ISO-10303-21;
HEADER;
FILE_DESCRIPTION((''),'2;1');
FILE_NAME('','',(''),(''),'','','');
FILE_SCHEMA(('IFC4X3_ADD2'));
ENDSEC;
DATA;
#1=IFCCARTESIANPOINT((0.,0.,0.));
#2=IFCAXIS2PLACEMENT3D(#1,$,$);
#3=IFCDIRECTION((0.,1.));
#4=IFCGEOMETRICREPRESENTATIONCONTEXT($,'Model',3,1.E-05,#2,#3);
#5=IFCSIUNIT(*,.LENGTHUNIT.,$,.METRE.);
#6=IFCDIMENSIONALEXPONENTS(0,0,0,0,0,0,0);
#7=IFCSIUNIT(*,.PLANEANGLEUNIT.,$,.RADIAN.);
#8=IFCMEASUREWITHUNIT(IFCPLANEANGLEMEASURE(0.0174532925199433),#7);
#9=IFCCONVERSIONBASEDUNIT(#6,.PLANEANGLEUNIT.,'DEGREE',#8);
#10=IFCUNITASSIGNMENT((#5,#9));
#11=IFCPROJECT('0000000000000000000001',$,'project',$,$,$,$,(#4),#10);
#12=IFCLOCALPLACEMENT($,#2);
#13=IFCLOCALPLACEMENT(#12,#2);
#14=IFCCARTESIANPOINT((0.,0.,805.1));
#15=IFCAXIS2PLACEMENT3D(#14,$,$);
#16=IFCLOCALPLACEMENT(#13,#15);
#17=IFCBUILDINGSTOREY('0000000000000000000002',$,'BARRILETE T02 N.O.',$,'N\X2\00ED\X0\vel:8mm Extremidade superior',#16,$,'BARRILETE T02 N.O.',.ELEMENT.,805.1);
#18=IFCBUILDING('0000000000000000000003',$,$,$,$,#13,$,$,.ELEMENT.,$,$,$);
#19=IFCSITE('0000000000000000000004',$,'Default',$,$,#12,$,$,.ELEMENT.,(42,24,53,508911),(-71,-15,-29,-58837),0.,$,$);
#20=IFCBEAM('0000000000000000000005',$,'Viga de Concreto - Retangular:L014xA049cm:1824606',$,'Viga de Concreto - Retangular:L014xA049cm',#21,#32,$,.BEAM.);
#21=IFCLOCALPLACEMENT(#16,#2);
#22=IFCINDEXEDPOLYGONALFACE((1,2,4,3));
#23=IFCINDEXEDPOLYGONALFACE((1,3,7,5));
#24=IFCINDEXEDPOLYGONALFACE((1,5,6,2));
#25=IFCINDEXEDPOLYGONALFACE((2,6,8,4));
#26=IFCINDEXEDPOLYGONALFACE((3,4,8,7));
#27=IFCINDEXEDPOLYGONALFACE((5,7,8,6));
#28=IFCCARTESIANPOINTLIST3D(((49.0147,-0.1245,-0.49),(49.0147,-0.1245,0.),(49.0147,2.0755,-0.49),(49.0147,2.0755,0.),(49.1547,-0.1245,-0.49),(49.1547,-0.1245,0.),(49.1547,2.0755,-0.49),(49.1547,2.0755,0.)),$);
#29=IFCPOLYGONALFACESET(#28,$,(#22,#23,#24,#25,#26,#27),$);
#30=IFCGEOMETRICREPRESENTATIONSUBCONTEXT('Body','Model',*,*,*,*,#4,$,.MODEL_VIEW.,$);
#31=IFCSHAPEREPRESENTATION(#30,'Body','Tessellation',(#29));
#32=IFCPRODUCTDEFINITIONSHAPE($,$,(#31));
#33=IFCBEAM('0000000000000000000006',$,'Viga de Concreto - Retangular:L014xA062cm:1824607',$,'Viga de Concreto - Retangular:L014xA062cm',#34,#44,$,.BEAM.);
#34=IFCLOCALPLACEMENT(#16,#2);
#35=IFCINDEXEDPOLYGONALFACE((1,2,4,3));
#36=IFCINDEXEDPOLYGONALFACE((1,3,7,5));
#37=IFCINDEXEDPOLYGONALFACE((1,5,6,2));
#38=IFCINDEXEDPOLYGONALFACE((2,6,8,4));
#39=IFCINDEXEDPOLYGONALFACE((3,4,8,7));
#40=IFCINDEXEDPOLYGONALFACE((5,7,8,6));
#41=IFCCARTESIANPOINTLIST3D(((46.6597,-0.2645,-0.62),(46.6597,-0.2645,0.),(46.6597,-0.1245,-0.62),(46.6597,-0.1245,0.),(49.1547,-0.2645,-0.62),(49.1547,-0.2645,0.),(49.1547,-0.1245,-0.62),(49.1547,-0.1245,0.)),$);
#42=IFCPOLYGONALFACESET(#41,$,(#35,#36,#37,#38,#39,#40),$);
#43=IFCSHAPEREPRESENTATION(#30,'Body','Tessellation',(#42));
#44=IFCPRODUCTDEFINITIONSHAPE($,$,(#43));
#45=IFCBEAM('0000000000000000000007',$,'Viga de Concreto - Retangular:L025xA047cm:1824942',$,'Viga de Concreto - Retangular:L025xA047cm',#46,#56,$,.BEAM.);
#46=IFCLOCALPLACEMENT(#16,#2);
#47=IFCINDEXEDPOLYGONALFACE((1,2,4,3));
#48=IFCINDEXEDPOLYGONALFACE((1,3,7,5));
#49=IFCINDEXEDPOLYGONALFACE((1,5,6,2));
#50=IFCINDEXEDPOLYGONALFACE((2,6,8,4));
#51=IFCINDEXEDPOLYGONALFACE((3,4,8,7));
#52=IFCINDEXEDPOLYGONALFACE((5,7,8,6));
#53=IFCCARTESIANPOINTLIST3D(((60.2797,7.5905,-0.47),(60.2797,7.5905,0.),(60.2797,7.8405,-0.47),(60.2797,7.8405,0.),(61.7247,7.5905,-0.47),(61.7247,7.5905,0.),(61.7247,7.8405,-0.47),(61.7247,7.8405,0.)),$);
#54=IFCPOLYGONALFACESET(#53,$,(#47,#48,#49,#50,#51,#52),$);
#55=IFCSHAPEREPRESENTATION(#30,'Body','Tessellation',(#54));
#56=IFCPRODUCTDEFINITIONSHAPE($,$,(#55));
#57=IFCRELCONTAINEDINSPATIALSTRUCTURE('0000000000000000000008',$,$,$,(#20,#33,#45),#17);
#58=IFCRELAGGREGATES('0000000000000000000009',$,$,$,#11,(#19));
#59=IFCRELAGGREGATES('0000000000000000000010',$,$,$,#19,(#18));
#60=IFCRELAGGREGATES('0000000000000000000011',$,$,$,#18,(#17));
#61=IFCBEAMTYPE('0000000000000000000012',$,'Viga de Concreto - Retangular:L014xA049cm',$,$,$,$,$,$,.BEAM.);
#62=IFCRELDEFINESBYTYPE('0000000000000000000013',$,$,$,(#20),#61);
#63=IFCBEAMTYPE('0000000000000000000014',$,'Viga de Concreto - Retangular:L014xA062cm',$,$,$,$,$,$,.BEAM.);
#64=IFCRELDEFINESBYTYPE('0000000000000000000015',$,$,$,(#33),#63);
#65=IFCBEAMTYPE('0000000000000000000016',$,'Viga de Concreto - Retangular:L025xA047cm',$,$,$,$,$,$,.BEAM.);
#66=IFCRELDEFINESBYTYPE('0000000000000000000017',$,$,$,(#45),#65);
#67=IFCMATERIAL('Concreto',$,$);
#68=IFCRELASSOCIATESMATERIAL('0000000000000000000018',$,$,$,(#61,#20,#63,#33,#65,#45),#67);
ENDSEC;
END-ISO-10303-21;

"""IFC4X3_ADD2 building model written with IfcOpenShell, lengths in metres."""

from ifc_helpers import new_model, entity, si_unit, converted_unit, direction, frame, frame_2d, origin, origin_2d_with_axis, place, context, subcontext, project, spatial, polyline, segment, composite_curve, rectangle, outline, extrude, source, transform, mapped, material, material_profile, profile_set, profile_usage, type_object, type_shapes, element, save


model = new_model("IFC4X3_ADD2")

# Units and contexts
model_context = context("Model", 3, precision=1e-05, world=origin(), true_north=direction((0.0, 1.0)))
body_context = subcontext(model_context, "Body", "Model", "MODEL_VIEW")
ifc_project = project(units=[si_unit("LENGTHUNIT", "METRE"), converted_unit("PLANEANGLEUNIT", "DEGREE", entity("IfcPlaneAngleMeasure", 0.0174532925199433), si_unit("PLANEANGLEUNIT", "RADIAN"), dimensions=[0, 0, 0, 0, 0, 0, 0])], contexts=[model_context])

# Site, building, storey
site_placement = place(None, origin())
site = spatial("IfcSite", under=ifc_project, at=site_placement, Name="Default", CompositionType="ELEMENT", RefLatitude=(42, 24, 53, 508911), RefLongitude=(-71, -15, -29, -58837), RefElevation=0.0)
building_placement = place(site_placement, origin())
building = spatial("IfcBuilding", under=site, at=building_placement, CompositionType="ELEMENT")
storey_placement = place(building_placement, frame((0.0, 0.0, 805.1)))
storey = spatial("IfcBuildingStorey", under=building, at=storey_placement, Name="BARRILETE T02 N.O.", ObjectType="Nível:8mm Extremidade superior", LongName="BARRILETE T02 N.O.", CompositionType="ELEMENT", Elevation=805.1)

# Shared definitions
ifc_material = material(Name="Concreto")

# Beams
ifc_material_profile_1 = material_profile(ifc_material, rectangle(XDim=0.49, YDim=0.14, at=frame_2d((0.0, 0.0), x_axis=(0.0, 1.0))), Name="L014xA049cm")
ifc_profile_set_1 = profile_set([ifc_material_profile_1], Name="L014xA049cm")
ifc_profile_usage_1 = profile_usage(ifc_profile_set_1, cardinal=8)
ifc_material_profile_2 = material_profile(ifc_material, outline(composite_curve([segment(polyline([(-0.07, 0.31, 0.0), (0.07, 0.31, 0.0)]), True, "CONTINUOUS"), segment(polyline([(0.07, 0.31, 0.0), (0.07, -0.31, 0.0)]), True, "CONTINUOUS"), segment(polyline([(0.07, -0.31, 0.0), (-0.07, -0.31, 0.0)]), True, "CONTINUOUS"), segment(polyline([(-0.07, -0.31, 0.0), (-0.07, 0.31, 0.0)]), True, "CONTINUOUS")], self_intersect=False), kind="CURVE"), Name="L014xA062cm")
ifc_material_profile_3 = material_profile(ifc_material, outline(composite_curve([segment(polyline([(-2.2225, 0.07, 0.31), (-2.2225, 0.07, -0.31)]), True, "CONTINUOUS"), segment(polyline([(-2.2225, 0.07, -0.31), (-2.2225, -0.07, -0.31)]), True, "CONTINUOUS"), segment(polyline([(-2.2225, -0.07, -0.31), (-2.2225, -0.07, 0.31)]), True, "CONTINUOUS"), segment(polyline([(-2.2225, -0.07, 0.31), (-2.2225, 0.07, 0.31)]), True, "CONTINUOUS")], self_intersect=False), kind="CURVE"), Name="L014xA062cm")
ifc_profile_set_2 = profile_set([ifc_material_profile_2, ifc_material_profile_3], Name="L014xA062cm")
ifc_profile_usage_2 = profile_usage(ifc_profile_set_2, cardinal=8)
ifc_material_profile_4 = material_profile(ifc_material, rectangle(XDim=0.47, YDim=0.25, at=origin_2d_with_axis()), Name="L025xA047cm")
ifc_profile_set_3 = profile_set([ifc_material_profile_4], Name="L025xA047cm")
ifc_profile_usage_3 = profile_usage(ifc_profile_set_3, cardinal=8)
beam_type_1 = type_object("IfcBeamType", Name="Viga de Concreto - Retangular:L014xA049cm", PredefinedType="BEAM", material=ifc_profile_set_1)
shared_shape_1 = source(origin(), body_context, "Body", "SweptSolid", [
    extrude(rectangle(XDim=0.49, YDim=0.14, at=frame_2d((0.0, 0.0), x_axis=(0.0, 1.0))), frame((49.0847, 2.0755, 804.855), z_axis=(0.0, -1.0, 0.0), x_axis=(-1.0, 0.0, 0.0)), (0.0, 0.0, 1.0), 2.2),
])
type_shapes(beam_type_1, [shared_shape_1])
beam_1_placement = place(storey_placement, frame((0.0, 0.0, -805.1)))
element("IfcBeam", 1, at=beam_1_placement, inside=storey, type_object=beam_type_1, material=ifc_profile_usage_1, Name="Viga de Concreto - Retangular:L014xA049cm:1824606", ObjectType="Viga de Concreto - Retangular:L014xA049cm", PredefinedType="BEAM", context=body_context, shape_type="MappedRepresentation", body=[
    mapped(shared_shape_1, transform((0.0, 0.0, 0.0), scale=1.0)),
])
beam_type_2 = type_object("IfcBeamType", Name="Viga de Concreto - Retangular:L014xA062cm", PredefinedType="BEAM", material=ifc_profile_set_2)
shared_shape_2 = source(origin(), body_context, "Body", "SweptSolid", [
    extrude(rectangle(XDim=0.62, YDim=0.14, at=frame_2d((0.0, 0.0), x_axis=(1.0, 0.0))), frame((46.6597, -0.1945, 804.79), z_axis=(1.0, 0.0, 0.0), x_axis=(0.0, 0.0, -1.0)), (0.0, 0.0, 1.0), 2.495),
])
type_shapes(beam_type_2, [shared_shape_2])
beam_2_placement = place(storey_placement, frame((0.0, 0.0, -805.1)))
element("IfcBeam", 2, at=beam_2_placement, inside=storey, type_object=beam_type_2, material=ifc_profile_usage_2, Name="Viga de Concreto - Retangular:L014xA062cm:1824607", ObjectType="Viga de Concreto - Retangular:L014xA062cm", PredefinedType="BEAM", context=body_context, shape_type="MappedRepresentation", body=[
    mapped(shared_shape_2, transform((0.0, 0.0, 0.0), scale=1.0)),
])
beam_type_3 = type_object("IfcBeamType", Name="Viga de Concreto - Retangular:L025xA047cm", PredefinedType="BEAM", material=ifc_profile_set_3)
shared_shape_3 = source(origin(), body_context, "Body", "SweptSolid", [
    extrude(rectangle(XDim=0.47, YDim=0.25, at=frame_2d((0.0, 0.0), x_axis=(1.0, 0.0))), frame((61.7247, 7.7155, 804.865), z_axis=(-1.0, 0.0, 0.0), x_axis=(0.0, 0.0, -1.0)), (0.0, 0.0, 1.0), 1.445),
])
type_shapes(beam_type_3, [shared_shape_3])
beam_3_placement = place(storey_placement, frame((0.0, 0.0, -805.1)))
element("IfcBeam", 3, at=beam_3_placement, inside=storey, type_object=beam_type_3, material=ifc_profile_usage_3, Name="Viga de Concreto - Retangular:L025xA047cm:1824942", ObjectType="Viga de Concreto - Retangular:L025xA047cm", PredefinedType="BEAM", context=body_context, shape_type="MappedRepresentation", body=[
    mapped(shared_shape_3, transform((0.0, 0.0, 0.0), scale=1.0)),
])

save(model, "model.ifc")
